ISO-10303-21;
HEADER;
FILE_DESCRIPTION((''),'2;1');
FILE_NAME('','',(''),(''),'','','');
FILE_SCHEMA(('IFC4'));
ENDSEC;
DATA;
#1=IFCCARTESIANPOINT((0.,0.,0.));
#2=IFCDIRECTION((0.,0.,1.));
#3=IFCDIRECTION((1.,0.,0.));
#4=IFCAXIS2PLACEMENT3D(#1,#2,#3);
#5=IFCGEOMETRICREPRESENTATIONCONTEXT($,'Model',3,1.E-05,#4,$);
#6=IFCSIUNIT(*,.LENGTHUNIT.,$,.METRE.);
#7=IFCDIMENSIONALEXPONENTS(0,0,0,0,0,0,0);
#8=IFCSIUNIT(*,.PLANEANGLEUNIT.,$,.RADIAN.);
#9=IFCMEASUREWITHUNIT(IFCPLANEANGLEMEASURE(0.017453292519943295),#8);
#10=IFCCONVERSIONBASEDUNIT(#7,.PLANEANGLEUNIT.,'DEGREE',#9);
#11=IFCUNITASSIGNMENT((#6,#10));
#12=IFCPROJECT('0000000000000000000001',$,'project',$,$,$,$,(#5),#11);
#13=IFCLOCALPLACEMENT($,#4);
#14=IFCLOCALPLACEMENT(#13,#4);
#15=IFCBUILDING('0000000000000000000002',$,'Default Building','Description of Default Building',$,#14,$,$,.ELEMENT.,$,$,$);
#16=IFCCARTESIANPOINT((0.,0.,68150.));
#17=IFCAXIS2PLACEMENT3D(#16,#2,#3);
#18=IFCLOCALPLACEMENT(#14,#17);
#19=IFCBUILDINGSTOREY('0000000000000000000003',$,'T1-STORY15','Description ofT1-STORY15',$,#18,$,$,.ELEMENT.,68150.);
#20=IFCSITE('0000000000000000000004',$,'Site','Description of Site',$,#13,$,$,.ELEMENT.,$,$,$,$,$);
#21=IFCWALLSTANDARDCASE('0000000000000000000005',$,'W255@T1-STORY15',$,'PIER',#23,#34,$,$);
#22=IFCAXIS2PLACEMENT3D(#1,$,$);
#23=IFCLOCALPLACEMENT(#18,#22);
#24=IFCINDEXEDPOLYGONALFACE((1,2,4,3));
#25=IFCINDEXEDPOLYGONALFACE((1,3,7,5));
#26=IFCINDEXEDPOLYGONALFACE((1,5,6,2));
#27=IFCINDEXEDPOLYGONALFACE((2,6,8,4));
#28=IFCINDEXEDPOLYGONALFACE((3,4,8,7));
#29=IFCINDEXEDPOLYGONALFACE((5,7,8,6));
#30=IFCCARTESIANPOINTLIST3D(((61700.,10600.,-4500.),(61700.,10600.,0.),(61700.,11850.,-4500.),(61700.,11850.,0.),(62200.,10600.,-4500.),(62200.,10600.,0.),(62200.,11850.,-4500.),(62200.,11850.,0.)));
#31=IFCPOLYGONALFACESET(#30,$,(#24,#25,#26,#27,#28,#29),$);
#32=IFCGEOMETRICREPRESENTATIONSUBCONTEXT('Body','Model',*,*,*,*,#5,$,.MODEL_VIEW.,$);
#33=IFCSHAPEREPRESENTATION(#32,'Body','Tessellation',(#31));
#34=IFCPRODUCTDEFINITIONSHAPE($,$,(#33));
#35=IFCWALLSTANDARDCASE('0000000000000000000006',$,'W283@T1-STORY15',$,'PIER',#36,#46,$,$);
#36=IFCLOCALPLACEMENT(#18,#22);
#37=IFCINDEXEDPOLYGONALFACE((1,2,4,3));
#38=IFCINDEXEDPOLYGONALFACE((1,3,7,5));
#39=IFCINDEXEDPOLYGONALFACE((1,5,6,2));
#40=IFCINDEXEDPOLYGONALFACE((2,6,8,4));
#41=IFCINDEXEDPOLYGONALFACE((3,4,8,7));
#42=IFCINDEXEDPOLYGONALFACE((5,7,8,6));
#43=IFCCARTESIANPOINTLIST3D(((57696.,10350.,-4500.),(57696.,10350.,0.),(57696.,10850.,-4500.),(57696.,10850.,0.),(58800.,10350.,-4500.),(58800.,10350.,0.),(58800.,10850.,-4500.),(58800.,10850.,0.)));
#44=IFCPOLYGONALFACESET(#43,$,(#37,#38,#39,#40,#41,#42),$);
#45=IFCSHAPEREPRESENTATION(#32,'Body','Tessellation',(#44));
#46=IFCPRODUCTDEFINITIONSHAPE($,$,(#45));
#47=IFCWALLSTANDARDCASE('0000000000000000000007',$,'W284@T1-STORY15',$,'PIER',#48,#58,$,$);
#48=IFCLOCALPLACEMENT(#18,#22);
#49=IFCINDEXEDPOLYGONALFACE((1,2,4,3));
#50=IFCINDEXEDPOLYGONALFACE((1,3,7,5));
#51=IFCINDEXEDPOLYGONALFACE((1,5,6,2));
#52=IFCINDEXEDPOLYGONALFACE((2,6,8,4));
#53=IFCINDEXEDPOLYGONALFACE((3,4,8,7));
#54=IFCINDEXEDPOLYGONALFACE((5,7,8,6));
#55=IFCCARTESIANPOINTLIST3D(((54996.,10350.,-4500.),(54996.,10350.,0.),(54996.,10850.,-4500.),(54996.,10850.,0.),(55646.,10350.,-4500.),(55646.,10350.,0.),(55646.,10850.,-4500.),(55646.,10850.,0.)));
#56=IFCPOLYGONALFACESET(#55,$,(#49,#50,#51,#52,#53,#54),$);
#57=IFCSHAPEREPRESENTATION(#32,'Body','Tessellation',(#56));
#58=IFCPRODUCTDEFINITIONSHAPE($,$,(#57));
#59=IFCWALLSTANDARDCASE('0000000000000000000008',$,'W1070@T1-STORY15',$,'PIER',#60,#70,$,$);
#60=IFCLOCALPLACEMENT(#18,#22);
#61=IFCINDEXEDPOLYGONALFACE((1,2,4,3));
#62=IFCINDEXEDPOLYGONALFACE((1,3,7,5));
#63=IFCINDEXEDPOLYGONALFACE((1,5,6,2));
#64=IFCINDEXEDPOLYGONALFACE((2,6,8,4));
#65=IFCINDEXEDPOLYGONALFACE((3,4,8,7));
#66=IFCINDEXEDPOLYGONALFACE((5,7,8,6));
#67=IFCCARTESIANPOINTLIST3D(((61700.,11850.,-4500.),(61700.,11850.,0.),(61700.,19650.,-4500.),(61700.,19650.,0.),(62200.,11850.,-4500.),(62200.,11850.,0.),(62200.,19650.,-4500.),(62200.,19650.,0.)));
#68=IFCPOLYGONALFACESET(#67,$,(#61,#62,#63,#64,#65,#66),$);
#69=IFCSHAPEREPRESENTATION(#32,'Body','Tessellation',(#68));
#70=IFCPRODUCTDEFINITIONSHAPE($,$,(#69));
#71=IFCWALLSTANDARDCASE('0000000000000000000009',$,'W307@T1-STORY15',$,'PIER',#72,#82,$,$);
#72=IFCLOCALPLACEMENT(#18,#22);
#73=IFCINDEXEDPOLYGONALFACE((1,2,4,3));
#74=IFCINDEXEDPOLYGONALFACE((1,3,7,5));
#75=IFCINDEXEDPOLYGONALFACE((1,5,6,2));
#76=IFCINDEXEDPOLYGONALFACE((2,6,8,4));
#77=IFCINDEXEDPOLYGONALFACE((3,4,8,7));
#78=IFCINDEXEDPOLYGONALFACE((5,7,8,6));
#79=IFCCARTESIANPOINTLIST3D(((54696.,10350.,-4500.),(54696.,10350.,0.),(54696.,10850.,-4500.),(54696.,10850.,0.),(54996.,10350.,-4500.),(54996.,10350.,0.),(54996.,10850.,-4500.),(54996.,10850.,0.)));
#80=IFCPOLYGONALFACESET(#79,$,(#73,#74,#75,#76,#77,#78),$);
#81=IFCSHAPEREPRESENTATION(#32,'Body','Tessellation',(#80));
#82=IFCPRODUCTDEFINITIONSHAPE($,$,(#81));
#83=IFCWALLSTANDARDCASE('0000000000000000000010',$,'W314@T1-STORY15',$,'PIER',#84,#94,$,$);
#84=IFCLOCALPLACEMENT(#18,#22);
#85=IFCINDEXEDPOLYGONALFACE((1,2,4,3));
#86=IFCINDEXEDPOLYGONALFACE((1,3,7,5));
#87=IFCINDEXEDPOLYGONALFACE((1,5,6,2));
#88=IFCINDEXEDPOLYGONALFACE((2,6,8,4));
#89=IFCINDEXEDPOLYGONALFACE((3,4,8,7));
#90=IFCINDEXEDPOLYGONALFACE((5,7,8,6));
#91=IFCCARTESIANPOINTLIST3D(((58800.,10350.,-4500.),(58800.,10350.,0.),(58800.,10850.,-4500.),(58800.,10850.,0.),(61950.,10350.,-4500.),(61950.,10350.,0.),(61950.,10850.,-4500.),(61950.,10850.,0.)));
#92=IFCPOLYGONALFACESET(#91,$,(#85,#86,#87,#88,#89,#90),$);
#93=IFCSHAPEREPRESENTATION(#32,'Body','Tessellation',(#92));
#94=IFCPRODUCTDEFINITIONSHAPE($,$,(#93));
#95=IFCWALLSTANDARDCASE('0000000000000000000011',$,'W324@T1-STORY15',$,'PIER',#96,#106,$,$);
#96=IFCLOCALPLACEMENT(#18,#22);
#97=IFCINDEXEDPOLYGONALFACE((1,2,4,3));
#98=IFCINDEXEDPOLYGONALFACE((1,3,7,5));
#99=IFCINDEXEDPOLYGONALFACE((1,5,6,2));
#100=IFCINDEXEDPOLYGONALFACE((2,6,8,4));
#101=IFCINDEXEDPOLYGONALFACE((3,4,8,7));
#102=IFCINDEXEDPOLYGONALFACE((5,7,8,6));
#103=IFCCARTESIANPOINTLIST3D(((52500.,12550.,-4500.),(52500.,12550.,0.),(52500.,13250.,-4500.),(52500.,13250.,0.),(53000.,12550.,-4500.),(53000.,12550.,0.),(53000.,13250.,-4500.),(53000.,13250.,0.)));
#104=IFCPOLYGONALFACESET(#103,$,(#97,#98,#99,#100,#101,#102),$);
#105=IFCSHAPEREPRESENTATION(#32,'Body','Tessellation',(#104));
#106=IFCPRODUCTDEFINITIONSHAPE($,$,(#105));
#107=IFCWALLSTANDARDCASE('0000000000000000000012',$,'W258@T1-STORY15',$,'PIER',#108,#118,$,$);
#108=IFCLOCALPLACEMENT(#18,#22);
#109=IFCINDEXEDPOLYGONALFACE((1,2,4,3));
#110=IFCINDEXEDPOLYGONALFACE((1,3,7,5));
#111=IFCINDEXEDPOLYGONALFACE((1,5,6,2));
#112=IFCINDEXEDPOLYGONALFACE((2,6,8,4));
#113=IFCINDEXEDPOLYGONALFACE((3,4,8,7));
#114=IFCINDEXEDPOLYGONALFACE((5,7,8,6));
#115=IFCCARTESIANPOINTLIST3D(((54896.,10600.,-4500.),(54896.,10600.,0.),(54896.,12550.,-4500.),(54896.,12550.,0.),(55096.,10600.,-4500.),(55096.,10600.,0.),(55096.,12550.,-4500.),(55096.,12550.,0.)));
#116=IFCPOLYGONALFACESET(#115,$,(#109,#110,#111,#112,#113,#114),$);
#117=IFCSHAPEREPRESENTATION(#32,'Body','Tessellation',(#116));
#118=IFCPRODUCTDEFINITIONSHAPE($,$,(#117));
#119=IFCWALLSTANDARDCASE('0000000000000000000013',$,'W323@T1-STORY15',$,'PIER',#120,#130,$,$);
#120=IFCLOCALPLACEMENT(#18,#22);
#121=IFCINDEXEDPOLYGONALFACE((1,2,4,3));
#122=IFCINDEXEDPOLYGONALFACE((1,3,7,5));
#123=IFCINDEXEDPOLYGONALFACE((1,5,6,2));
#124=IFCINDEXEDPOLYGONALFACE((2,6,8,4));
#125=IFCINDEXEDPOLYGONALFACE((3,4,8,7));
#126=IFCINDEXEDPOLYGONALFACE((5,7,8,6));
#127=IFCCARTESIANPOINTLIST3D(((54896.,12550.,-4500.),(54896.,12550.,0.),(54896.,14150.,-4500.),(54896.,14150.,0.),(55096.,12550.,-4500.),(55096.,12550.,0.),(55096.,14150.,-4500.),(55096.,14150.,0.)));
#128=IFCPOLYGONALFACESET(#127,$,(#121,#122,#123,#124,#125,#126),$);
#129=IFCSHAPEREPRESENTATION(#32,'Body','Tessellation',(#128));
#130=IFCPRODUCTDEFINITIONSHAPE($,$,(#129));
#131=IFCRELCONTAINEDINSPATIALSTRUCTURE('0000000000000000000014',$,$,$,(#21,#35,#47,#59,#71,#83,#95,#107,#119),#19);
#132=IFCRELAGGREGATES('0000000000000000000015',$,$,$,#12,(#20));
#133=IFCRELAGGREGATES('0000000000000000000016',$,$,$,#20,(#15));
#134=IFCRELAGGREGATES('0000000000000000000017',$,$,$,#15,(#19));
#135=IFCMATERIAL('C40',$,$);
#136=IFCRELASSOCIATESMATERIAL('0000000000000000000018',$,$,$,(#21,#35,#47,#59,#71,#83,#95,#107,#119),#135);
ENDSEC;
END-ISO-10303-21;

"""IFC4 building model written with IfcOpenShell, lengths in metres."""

from ifc_helpers import new_model, entity, si_unit, converted_unit, frame, origin_with_axes, place, context, subcontext, project, spatial, indexed_curve, outline, extrude, material, element, save


model = new_model("IFC4")

# Units and contexts
model_context = context("Model", 3, precision=1e-05, world=origin_with_axes())
body_context = subcontext(model_context, "Body", "Model", "MODEL_VIEW")
ifc_project = project(units=[si_unit("LENGTHUNIT", "METRE"), converted_unit("PLANEANGLEUNIT", "DEGREE", entity("IfcPlaneAngleMeasure", 0.017453292519943295), si_unit("PLANEANGLEUNIT", "RADIAN"), dimensions=[0, 0, 0, 0, 0, 0, 0])], contexts=[model_context])

# Site, building, storey
site_placement = place(None, origin_with_axes())
site = spatial("IfcSite", under=ifc_project, at=site_placement, Name="Site", Description="Description of Site", CompositionType="ELEMENT")
building_placement = place(site_placement, origin_with_axes())
building = spatial("IfcBuilding", under=site, at=building_placement, Name="Default Building", Description="Description of Default Building", CompositionType="ELEMENT")
storey_placement = place(building_placement, frame((0.0, 0.0, 68150.0), z_axis=(0.0, 0.0, 1.0), x_axis=(1.0, 0.0, 0.0)))
storey = spatial("IfcBuildingStorey", under=building, at=storey_placement, Name="T1-STORY15", Description="Description ofT1-STORY15", CompositionType="ELEMENT", Elevation=68150.0)

# Walls
ifc_material_1 = material(Name="C40")
wall_1_placement = place(storey_placement, frame((61950.0, 10600.0, -4500.0), z_axis=(0.0, 0.0, 1.0), x_axis=(0.0, 1.0, 0.0)))
element("IfcWallStandardCase", 1, at=wall_1_placement, inside=storey, material=ifc_material_1, Name="W255@T1-STORY15", ObjectType="PIER", context=body_context, shape_type="SweptSolid", body=[
    extrude(outline(indexed_curve([(0.0, -250.0), (0.0, 250.0), (1250.0, 250.0), (1250.0, -250.0), (0.0, -250.0)], self_intersect=False)), origin_with_axes(), (0.0, 0.0, 1.0), 4500.0),
])
wall_2_placement = place(storey_placement, frame((57696.0, 10600.0, -4500.0), z_axis=(0.0, 0.0, 1.0), x_axis=(1.0, 0.0, 0.0)))
element("IfcWallStandardCase", 2, at=wall_2_placement, inside=storey, material=ifc_material_1, Name="W283@T1-STORY15", ObjectType="PIER", context=body_context, shape_type="SweptSolid", body=[
    extrude(outline(indexed_curve([(0.0, -250.0), (0.0, 250.0), (1104.0, 250.0), (1104.0, -250.0), (0.0, -250.0)], self_intersect=False)), origin_with_axes(), (0.0, 0.0, 1.0), 4500.0),
])
wall_3_placement = place(storey_placement, frame((54996.0, 10600.0, -4500.0), z_axis=(0.0, 0.0, 1.0), x_axis=(1.0, 0.0, 0.0)))
element("IfcWallStandardCase", 3, at=wall_3_placement, inside=storey, material=ifc_material_1, Name="W284@T1-STORY15", ObjectType="PIER", context=body_context, shape_type="SweptSolid", body=[
    extrude(outline(indexed_curve([(0.0, -250.0), (0.0, 250.0), (650.0, 250.0), (650.0, -250.0), (0.0, -250.0)], self_intersect=False)), origin_with_axes(), (0.0, 0.0, 1.0), 4500.0),
])
wall_4_placement = place(storey_placement, frame((61950.0, 11850.0, -4500.0), z_axis=(0.0, 0.0, 1.0), x_axis=(0.0, 1.0, 0.0)))
element("IfcWallStandardCase", 4, at=wall_4_placement, inside=storey, material=ifc_material_1, Name="W1070@T1-STORY15", ObjectType="PIER", context=body_context, shape_type="SweptSolid", body=[
    extrude(outline(indexed_curve([(0.0, -250.0), (0.0, 250.0), (7800.0, 250.0), (7800.0, -250.0), (0.0, -250.0)], self_intersect=False)), origin_with_axes(), (0.0, 0.0, 1.0), 4500.0),
])
wall_5_placement = place(storey_placement, frame((54696.0, 10600.0, -4500.0), z_axis=(0.0, 0.0, 1.0), x_axis=(1.0, 0.0, 0.0)))
element("IfcWallStandardCase", 5, at=wall_5_placement, inside=storey, material=ifc_material_1, Name="W307@T1-STORY15", ObjectType="PIER", context=body_context, shape_type="SweptSolid", body=[
    extrude(outline(indexed_curve([(0.0, -250.0), (0.0, 250.0), (300.0, 250.0), (300.0, -250.0), (0.0, -250.0)], self_intersect=False)), origin_with_axes(), (0.0, 0.0, 1.0), 4500.0),
])
wall_6_placement = place(storey_placement, frame((58800.0, 10600.0, -4500.0), z_axis=(0.0, 0.0, 1.0), x_axis=(1.0, 0.0, 0.0)))
element("IfcWallStandardCase", 6, at=wall_6_placement, inside=storey, material=ifc_material_1, Name="W314@T1-STORY15", ObjectType="PIER", context=body_context, shape_type="SweptSolid", body=[
    extrude(outline(indexed_curve([(0.0, -250.0), (0.0, 250.0), (3150.0, 250.0), (3150.0, -250.0), (0.0, -250.0)], self_intersect=False)), origin_with_axes(), (0.0, 0.0, 1.0), 4500.0),
])
wall_7_placement = place(storey_placement, frame((52750.0, 12550.0, -4500.0), z_axis=(0.0, 0.0, 1.0), x_axis=(0.0, 1.0, 0.0)))
element("IfcWallStandardCase", 7, at=wall_7_placement, inside=storey, material=ifc_material_1, Name="W324@T1-STORY15", ObjectType="PIER", context=body_context, shape_type="SweptSolid", body=[
    extrude(outline(indexed_curve([(0.0, -250.0), (0.0, 250.0), (700.0, 250.0), (700.0, -250.0), (0.0, -250.0)], self_intersect=False)), origin_with_axes(), (0.0, 0.0, 1.0), 4500.0),
])
wall_8_placement = place(storey_placement, frame((54996.0, 10600.0, -4500.0), z_axis=(0.0, 0.0, 1.0), x_axis=(0.0, 1.0, 0.0)))
element("IfcWallStandardCase", 8, at=wall_8_placement, inside=storey, material=ifc_material_1, Name="W258@T1-STORY15", ObjectType="PIER", context=body_context, shape_type="SweptSolid", body=[
    extrude(outline(indexed_curve([(0.0, -100.0), (0.0, 100.0), (1950.0, 100.0), (1950.0, -100.0), (0.0, -100.0)], self_intersect=False)), origin_with_axes(), (0.0, 0.0, 1.0), 4500.0),
])
wall_9_placement = place(storey_placement, frame((54996.0, 12550.0, -4500.0), z_axis=(0.0, 0.0, 1.0), x_axis=(0.0, 1.0, 0.0)))
element("IfcWallStandardCase", 9, at=wall_9_placement, inside=storey, material=ifc_material_1, Name="W323@T1-STORY15", ObjectType="PIER", context=body_context, shape_type="SweptSolid", body=[
    extrude(outline(indexed_curve([(0.0, -100.0), (0.0, 100.0), (1600.0, 100.0), (1600.0, -100.0), (0.0, -100.0)], self_intersect=False)), origin_with_axes(), (0.0, 0.0, 1.0), 4500.0),
])

save(model, "model.ifc")
